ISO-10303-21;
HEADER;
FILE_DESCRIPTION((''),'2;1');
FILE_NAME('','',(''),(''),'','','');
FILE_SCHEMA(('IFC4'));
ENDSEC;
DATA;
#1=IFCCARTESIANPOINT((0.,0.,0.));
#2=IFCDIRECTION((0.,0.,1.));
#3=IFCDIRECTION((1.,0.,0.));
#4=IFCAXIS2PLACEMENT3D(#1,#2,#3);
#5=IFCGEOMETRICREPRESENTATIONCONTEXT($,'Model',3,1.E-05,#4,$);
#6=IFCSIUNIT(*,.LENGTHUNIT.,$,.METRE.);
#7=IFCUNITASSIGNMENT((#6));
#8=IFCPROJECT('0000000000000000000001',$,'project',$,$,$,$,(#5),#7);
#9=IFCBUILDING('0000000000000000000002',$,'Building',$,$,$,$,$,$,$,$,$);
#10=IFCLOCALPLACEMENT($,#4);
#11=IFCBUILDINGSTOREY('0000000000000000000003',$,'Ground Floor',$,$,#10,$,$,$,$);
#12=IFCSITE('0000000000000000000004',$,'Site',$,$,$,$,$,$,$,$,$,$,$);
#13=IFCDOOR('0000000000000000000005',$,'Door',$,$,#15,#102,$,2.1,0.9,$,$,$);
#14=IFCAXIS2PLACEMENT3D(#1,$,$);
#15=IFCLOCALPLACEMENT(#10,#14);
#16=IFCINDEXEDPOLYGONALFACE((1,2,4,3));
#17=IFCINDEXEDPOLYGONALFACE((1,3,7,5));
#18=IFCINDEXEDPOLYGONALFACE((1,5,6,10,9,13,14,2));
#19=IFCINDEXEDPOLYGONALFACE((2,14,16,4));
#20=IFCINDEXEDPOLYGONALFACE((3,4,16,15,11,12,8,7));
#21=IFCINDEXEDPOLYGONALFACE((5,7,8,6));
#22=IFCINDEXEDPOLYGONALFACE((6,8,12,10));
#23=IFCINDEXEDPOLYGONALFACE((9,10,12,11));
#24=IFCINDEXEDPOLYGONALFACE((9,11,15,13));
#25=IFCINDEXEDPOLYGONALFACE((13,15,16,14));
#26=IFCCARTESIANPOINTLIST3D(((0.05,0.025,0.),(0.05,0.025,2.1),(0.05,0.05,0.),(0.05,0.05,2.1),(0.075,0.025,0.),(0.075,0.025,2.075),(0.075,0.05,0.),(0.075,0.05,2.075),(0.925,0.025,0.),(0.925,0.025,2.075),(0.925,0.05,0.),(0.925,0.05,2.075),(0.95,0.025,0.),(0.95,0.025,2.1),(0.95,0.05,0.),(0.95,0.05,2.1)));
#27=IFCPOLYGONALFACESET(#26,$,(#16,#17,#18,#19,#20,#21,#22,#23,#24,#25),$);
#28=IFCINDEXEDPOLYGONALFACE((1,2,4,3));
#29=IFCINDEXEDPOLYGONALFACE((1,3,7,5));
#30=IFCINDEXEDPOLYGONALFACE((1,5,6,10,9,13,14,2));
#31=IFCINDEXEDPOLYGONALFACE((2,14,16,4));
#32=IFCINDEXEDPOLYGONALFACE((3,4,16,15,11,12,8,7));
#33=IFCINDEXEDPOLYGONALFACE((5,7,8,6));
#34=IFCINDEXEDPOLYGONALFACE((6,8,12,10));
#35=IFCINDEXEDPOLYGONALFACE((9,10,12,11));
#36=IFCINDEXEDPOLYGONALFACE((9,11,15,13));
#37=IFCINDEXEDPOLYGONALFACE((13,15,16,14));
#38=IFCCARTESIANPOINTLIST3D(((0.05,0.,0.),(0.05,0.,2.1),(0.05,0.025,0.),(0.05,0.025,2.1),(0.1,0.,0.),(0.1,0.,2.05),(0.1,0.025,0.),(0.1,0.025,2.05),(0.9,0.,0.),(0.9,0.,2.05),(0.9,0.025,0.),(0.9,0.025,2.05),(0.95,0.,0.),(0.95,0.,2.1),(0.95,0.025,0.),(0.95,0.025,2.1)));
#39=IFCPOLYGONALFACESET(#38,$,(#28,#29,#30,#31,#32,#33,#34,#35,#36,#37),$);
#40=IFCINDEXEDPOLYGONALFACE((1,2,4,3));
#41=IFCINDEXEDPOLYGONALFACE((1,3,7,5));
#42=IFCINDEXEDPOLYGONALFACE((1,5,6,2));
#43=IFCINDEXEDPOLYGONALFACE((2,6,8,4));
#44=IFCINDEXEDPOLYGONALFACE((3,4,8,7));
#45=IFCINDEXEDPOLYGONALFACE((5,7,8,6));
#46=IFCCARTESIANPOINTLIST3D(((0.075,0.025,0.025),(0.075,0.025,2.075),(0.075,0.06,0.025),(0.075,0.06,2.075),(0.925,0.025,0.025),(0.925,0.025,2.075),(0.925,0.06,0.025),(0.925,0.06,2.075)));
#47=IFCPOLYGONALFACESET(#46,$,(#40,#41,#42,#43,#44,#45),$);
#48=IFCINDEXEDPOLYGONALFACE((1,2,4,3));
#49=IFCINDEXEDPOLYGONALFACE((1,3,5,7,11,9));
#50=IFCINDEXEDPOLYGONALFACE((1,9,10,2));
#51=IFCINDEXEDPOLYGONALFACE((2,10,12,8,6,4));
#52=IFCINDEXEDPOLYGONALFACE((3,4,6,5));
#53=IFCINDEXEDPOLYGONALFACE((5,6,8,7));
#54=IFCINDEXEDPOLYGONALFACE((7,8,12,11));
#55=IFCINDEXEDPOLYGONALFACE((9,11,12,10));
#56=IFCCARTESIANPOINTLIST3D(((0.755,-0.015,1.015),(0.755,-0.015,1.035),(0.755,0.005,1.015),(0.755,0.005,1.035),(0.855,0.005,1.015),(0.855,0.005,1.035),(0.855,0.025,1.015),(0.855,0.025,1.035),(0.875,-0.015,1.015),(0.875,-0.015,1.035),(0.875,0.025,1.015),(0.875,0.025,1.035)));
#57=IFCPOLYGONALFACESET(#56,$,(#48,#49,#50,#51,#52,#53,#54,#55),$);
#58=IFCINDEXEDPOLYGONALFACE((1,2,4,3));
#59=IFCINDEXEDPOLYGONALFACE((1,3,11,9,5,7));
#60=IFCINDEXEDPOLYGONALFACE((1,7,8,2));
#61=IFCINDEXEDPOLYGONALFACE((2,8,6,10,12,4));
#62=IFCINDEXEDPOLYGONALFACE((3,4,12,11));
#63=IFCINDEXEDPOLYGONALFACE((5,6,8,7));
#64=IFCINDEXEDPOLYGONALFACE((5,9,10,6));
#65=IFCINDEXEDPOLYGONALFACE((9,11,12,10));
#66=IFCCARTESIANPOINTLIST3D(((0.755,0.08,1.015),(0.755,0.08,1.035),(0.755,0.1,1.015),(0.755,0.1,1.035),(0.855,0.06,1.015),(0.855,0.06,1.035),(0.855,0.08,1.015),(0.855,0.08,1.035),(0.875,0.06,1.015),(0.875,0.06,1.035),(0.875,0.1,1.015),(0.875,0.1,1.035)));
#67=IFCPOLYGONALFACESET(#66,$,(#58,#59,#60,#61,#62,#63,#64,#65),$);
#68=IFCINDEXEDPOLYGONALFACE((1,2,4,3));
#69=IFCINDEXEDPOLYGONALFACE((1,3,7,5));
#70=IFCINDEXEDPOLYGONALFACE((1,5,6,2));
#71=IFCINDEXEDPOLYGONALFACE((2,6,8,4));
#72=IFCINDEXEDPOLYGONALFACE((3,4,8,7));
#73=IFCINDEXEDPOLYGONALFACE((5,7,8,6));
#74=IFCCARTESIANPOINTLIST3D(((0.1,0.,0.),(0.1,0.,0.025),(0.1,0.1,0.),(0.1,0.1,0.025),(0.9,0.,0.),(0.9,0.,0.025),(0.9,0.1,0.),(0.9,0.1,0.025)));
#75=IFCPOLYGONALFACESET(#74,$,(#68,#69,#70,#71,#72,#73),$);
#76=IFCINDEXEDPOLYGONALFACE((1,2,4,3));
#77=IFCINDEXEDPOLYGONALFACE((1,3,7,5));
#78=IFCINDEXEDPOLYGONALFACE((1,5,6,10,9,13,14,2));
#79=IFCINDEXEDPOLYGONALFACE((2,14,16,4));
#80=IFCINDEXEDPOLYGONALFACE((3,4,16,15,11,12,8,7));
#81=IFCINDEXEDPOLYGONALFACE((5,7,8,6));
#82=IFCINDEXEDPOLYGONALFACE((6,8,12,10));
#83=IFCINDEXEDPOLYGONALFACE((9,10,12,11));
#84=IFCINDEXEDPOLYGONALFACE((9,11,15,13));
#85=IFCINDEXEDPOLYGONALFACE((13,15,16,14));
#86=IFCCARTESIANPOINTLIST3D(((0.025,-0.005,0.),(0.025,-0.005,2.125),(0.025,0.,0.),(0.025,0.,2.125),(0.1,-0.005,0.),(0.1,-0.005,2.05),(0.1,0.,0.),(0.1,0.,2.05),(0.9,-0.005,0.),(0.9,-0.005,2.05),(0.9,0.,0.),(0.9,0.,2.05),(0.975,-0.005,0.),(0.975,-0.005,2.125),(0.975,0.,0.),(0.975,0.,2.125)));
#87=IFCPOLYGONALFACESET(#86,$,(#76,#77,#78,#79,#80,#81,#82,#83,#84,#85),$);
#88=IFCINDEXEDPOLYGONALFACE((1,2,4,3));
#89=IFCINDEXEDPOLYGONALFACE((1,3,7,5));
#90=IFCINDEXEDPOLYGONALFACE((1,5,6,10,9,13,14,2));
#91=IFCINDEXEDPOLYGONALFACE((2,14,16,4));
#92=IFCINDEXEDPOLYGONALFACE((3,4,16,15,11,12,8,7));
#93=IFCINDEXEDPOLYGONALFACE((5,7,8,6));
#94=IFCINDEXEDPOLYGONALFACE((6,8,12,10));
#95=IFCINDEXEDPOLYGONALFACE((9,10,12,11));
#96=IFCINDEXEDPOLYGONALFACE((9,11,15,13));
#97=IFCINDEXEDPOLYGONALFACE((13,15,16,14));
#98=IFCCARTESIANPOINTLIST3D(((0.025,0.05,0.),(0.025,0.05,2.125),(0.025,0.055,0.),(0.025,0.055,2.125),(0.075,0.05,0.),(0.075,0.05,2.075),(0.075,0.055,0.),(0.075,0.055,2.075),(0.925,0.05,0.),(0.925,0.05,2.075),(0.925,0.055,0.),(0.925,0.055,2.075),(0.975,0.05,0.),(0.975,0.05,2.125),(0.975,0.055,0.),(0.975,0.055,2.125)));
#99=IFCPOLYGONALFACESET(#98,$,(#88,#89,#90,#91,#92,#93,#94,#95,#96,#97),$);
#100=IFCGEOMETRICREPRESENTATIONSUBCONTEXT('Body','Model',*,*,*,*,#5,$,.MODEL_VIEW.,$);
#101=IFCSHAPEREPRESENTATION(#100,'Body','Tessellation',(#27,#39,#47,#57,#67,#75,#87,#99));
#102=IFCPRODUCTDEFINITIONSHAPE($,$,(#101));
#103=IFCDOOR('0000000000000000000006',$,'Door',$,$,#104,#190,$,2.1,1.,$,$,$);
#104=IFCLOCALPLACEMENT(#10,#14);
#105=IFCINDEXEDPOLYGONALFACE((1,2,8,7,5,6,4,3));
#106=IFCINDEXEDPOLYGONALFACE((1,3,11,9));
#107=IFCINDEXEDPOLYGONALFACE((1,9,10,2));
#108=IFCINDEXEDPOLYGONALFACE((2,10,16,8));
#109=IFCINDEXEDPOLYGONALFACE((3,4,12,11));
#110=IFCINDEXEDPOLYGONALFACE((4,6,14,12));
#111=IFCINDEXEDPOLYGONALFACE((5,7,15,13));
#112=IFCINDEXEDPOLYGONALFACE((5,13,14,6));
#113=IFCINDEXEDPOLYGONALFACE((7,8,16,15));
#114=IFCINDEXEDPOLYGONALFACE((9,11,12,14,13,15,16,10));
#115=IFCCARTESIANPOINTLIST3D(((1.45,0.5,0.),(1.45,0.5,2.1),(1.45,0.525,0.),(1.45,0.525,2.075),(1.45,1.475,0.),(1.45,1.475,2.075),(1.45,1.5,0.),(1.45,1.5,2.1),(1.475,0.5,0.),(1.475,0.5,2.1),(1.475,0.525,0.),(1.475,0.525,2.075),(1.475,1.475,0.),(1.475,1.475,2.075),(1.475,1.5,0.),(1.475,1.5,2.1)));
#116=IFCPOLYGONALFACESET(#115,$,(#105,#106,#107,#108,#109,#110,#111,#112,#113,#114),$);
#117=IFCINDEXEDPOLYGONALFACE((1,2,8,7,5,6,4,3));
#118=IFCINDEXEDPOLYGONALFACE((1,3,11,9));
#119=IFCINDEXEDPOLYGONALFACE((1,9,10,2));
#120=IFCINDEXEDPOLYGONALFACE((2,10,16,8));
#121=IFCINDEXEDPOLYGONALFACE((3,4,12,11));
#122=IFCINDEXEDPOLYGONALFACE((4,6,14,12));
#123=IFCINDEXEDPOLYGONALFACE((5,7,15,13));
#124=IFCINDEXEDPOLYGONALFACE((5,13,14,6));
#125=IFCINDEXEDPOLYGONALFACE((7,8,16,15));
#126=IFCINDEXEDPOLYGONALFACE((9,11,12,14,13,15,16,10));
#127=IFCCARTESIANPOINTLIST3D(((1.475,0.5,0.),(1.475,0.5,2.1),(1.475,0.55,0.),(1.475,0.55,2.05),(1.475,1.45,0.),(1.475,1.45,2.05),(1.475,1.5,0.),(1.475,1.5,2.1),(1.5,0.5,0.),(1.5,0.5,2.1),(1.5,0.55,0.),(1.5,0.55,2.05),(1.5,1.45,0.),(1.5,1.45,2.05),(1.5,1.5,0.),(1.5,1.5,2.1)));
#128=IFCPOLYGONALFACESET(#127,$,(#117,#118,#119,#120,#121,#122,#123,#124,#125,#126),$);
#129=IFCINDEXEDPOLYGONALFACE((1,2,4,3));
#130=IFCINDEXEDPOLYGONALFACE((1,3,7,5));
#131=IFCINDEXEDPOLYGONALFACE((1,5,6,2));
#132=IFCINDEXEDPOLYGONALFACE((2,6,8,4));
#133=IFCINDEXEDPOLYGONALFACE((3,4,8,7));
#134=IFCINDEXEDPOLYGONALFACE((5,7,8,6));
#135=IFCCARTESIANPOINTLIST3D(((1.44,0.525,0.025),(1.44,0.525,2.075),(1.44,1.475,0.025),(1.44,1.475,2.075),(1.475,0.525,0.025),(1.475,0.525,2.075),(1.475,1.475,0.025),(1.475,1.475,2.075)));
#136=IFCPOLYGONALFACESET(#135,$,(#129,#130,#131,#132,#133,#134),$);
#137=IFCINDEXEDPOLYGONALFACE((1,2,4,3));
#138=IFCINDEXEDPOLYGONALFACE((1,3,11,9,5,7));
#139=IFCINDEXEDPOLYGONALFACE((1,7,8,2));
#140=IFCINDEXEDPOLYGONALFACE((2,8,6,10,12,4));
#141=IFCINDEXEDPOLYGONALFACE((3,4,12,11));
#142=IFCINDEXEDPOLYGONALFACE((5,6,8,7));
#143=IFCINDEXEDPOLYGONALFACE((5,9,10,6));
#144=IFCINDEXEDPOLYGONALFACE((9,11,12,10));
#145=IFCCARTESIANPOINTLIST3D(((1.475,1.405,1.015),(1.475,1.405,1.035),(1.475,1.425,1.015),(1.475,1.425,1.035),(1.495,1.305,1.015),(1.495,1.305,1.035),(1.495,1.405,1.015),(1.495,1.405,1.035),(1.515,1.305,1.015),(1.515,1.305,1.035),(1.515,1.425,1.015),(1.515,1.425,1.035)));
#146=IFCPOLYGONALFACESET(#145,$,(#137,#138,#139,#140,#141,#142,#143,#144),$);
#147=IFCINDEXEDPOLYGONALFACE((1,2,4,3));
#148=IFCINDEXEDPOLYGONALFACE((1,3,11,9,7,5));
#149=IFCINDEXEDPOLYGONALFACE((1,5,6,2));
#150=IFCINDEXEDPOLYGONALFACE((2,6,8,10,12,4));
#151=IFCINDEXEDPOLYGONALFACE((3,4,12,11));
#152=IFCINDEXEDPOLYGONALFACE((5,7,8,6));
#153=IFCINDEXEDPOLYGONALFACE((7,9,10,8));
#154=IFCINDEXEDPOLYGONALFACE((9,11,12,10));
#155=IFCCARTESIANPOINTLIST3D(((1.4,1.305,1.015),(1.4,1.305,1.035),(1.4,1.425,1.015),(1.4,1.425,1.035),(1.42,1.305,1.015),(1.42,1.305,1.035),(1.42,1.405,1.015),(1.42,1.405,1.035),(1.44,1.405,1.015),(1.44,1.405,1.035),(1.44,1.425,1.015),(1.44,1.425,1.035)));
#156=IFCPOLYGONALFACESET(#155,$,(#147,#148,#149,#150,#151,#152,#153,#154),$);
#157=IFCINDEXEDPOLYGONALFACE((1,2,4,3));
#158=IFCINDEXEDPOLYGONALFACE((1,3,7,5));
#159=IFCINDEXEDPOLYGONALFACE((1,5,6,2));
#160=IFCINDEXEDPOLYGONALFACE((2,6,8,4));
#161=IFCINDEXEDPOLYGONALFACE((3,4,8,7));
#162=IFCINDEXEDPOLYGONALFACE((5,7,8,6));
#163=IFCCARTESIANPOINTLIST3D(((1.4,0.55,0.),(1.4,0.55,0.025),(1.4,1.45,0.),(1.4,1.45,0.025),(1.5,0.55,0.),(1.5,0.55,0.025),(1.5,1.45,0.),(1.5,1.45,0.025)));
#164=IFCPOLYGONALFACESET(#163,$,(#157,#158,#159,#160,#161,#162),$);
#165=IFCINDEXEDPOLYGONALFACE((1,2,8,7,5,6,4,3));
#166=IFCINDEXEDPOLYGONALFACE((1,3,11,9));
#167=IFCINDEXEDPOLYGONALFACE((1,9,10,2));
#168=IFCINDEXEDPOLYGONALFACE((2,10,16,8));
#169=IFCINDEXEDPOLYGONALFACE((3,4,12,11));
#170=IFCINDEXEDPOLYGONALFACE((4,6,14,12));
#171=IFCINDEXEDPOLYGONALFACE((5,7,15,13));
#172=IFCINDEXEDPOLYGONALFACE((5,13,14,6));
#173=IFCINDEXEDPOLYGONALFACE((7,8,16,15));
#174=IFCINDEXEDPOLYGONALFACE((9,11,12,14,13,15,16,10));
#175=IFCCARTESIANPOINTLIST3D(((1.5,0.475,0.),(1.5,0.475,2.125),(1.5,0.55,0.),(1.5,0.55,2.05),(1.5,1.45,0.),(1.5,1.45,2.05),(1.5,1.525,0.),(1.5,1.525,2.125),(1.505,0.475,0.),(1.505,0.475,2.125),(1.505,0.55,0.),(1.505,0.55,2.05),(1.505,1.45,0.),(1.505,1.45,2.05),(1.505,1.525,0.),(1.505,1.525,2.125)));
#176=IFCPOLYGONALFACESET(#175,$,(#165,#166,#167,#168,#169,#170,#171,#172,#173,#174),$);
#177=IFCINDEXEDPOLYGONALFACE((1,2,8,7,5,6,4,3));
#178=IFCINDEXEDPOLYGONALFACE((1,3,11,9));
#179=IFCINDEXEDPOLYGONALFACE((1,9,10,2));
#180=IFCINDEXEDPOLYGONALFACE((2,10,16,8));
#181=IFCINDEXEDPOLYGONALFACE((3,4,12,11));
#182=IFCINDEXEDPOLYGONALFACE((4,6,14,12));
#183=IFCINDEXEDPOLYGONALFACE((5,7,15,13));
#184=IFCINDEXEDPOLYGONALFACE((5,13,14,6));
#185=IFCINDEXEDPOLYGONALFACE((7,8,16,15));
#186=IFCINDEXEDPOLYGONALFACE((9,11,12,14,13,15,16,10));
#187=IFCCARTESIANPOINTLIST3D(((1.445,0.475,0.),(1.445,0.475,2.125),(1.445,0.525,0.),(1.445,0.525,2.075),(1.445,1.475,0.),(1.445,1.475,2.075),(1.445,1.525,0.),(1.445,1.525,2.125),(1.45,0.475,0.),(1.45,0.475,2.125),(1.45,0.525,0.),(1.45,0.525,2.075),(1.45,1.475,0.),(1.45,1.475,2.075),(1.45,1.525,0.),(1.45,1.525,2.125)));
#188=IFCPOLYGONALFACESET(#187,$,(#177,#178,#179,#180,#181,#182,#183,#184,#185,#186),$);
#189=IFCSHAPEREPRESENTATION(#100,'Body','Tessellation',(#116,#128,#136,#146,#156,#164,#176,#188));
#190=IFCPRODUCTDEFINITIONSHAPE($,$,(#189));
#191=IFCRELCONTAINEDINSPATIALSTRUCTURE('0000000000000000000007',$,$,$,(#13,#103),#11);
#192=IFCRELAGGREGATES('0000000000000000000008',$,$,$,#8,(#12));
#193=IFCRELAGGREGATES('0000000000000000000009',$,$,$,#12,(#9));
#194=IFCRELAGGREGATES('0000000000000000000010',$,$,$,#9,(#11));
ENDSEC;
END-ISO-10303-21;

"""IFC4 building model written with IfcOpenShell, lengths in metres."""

from ifc_helpers import new_model, si_unit, frame, origin_with_axes, place, context, subcontext, project, spatial, line, indexed_curve, outline, extrude, element, save


model = new_model("IFC4")

# Units and contexts
model_context = context("Model", 3, precision=1e-05, world=origin_with_axes())
body_context = subcontext(model_context, "Body", "Model", "MODEL_VIEW")
ifc_project = project(units=[si_unit("LENGTHUNIT", "METRE")], contexts=[model_context])

# Site, building, storey
site = spatial("IfcSite", under=ifc_project, Name="Site")
building = spatial("IfcBuilding", under=site, Name="Building")
storey_placement = place(None, origin_with_axes())
storey = spatial("IfcBuildingStorey", under=building, at=storey_placement, Name="Ground Floor")

# Doors
door_1_placement = place(storey_placement, frame((0.05, 0.0, 0.0), z_axis=(0.0, 0.0, 1.0), x_axis=(1.0, 0.0, 0.0)))
element("IfcDoor", 1, at=door_1_placement, inside=storey, Name="Door", OverallHeight=2.1, OverallWidth=0.9, context=body_context, shape_type="SweptSolid", body=[
    extrude(outline(indexed_curve([(0.0, 0.0), (0.0, 2.1), (0.9, 2.1), (0.9, 0.0), (0.875, 0.0), (0.875, 2.075), (0.025, 2.075), (0.025, 0.0)], segments=[line(1, 2, 3, 4, 5, 6, 7, 8, 1)])), frame((0.0, 0.025, 0.0), z_axis=(0.0, -1.0, 0.0), x_axis=(1.0, 0.0, 0.0)), (0.0, 0.0, -1.0), 0.025),
    extrude(outline(indexed_curve([(0.0, 0.0), (0.0, 2.1), (0.9, 2.1), (0.9, 0.0), (0.85, 0.0), (0.85, 2.05), (0.05, 2.05), (0.05, 0.0)], segments=[line(1, 2, 3, 4, 5, 6, 7, 8, 1)])), frame((0.0, 0.0, 0.0), z_axis=(0.0, -1.0, 0.0), x_axis=(1.0, 0.0, 0.0)), (0.0, 0.0, -1.0), 0.025),
    extrude(outline(indexed_curve([(0.0, 0.0), (0.85, 0.0), (0.85, 0.035), (0.0, 0.035)], segments=[line(1, 2, 3, 4, 1)])), frame((0.025, 0.025, 0.025), z_axis=(0.0, 0.0, 1.0), x_axis=(1.0, 0.0, 0.0)), (0.0, 0.0, 1.0), 2.05),
    extrude(outline(indexed_curve([(0.0, 0.0), (0.0, -0.04), (-0.12, -0.04), (-0.12, -0.02), (-0.02, -0.02), (-0.02, 0.0)], segments=[line(1, 2, 3, 4, 5, 6, 1)])), frame((0.825, 0.025, 1.015), z_axis=(0.0, 0.0, 1.0), x_axis=(1.0, 0.0, 0.0)), (0.0, 0.0, 1.0), 0.02),
    extrude(outline(indexed_curve([(0.0, 0.0), (0.0, 0.04), (-0.12, 0.04), (-0.12, 0.02), (-0.02, 0.02), (-0.02, 0.0)], segments=[line(1, 2, 3, 4, 5, 6, 1)])), frame((0.825, 0.06, 1.015), z_axis=(0.0, 0.0, 1.0), x_axis=(1.0, 0.0, 0.0)), (0.0, 0.0, 1.0), 0.02),
    extrude(outline(indexed_curve([(0.0, 0.0), (0.8, 0.0), (0.8, 0.1), (0.0, 0.1)], segments=[line(1, 2, 3, 4, 1)])), frame((0.05, 0.0, 0.0), z_axis=(0.0, 0.0, 1.0), x_axis=(1.0, 0.0, 0.0)), (0.0, 0.0, 1.0), 0.025),
    extrude(outline(indexed_curve([(0.0, 0.0), (0.0, 2.125), (0.95, 2.125), (0.95, 0.0), (0.875, 0.0), (0.875, 2.05), (0.075, 2.05), (0.075, 0.0)], segments=[line(1, 2, 3, 4, 5, 6, 7, 8, 1)])), frame((-0.025, -0.005, 0.0), z_axis=(0.0, -1.0, 0.0), x_axis=(1.0, 0.0, 0.0)), (0.0, 0.0, -1.0), 0.005),
    extrude(outline(indexed_curve([(0.0, 0.0), (0.0, 2.125), (0.95, 2.125), (0.95, 0.0), (0.9, 0.0), (0.9, 2.075), (0.05, 2.075), (0.05, 0.0)], segments=[line(1, 2, 3, 4, 5, 6, 7, 8, 1)])), frame((-0.025, 0.05, 0.0), z_axis=(0.0, -1.0, 0.0), x_axis=(1.0, 0.0, 0.0)), (0.0, 0.0, -1.0), 0.005),
])
door_2_placement = place(storey_placement, frame((1.5, 0.5, 0.0), z_axis=(0.0, 0.0, 1.0), x_axis=(0.0, 1.0, 0.0)))
element("IfcDoor", 2, at=door_2_placement, inside=storey, Name="Door", OverallHeight=2.1, OverallWidth=1.0, context=body_context, shape_type="SweptSolid", body=[
    extrude(outline(indexed_curve([(0.0, 0.0), (0.0, 2.1), (1.0, 2.1), (1.0, 0.0), (0.975, 0.0), (0.975, 2.075), (0.025, 2.075), (0.025, 0.0)], segments=[line(1, 2, 3, 4, 5, 6, 7, 8, 1)])), frame((0.0, 0.025, 0.0), z_axis=(0.0, -1.0, 0.0), x_axis=(1.0, 0.0, 0.0)), (0.0, 0.0, -1.0), 0.025),
    extrude(outline(indexed_curve([(0.0, 0.0), (0.0, 2.1), (1.0, 2.1), (1.0, 0.0), (0.95, 0.0), (0.95, 2.05), (0.05, 2.05), (0.05, 0.0)], segments=[line(1, 2, 3, 4, 5, 6, 7, 8, 1)])), frame((0.0, 0.0, 0.0), z_axis=(0.0, -1.0, 0.0), x_axis=(1.0, 0.0, 0.0)), (0.0, 0.0, -1.0), 0.025),
    extrude(outline(indexed_curve([(0.0, 0.0), (0.95, 0.0), (0.95, 0.035), (0.0, 0.035)], segments=[line(1, 2, 3, 4, 1)])), frame((0.025, 0.025, 0.025), z_axis=(0.0, 0.0, 1.0), x_axis=(1.0, 0.0, 0.0)), (0.0, 0.0, 1.0), 2.05),
    extrude(outline(indexed_curve([(0.0, 0.0), (0.0, -0.04), (-0.12, -0.04), (-0.12, -0.02), (-0.02, -0.02), (-0.02, 0.0)], segments=[line(1, 2, 3, 4, 5, 6, 1)])), frame((0.925, 0.025, 1.015), z_axis=(0.0, 0.0, 1.0), x_axis=(1.0, 0.0, 0.0)), (0.0, 0.0, 1.0), 0.02),
    extrude(outline(indexed_curve([(0.0, 0.0), (0.0, 0.04), (-0.12, 0.04), (-0.12, 0.02), (-0.02, 0.02), (-0.02, 0.0)], segments=[line(1, 2, 3, 4, 5, 6, 1)])), frame((0.925, 0.06, 1.015), z_axis=(0.0, 0.0, 1.0), x_axis=(1.0, 0.0, 0.0)), (0.0, 0.0, 1.0), 0.02),
    extrude(outline(indexed_curve([(0.0, 0.0), (0.9, 0.0), (0.9, 0.1), (0.0, 0.1)], segments=[line(1, 2, 3, 4, 1)])), frame((0.05, 0.0, 0.0), z_axis=(0.0, 0.0, 1.0), x_axis=(1.0, 0.0, 0.0)), (0.0, 0.0, 1.0), 0.025),
    extrude(outline(indexed_curve([(0.0, 0.0), (0.0, 2.125), (1.05, 2.125), (1.05, 0.0), (0.975, 0.0), (0.975, 2.05), (0.075, 2.05), (0.075, 0.0)], segments=[line(1, 2, 3, 4, 5, 6, 7, 8, 1)])), frame((-0.025, -0.005, 0.0), z_axis=(0.0, -1.0, 0.0), x_axis=(1.0, 0.0, 0.0)), (0.0, 0.0, -1.0), 0.005),
    extrude(outline(indexed_curve([(0.0, 0.0), (0.0, 2.125), (1.05, 2.125), (1.05, 0.0), (1.0, 0.0), (1.0, 2.075), (0.05, 2.075), (0.05, 0.0)], segments=[line(1, 2, 3, 4, 5, 6, 7, 8, 1)])), frame((-0.025, 0.05, 0.0), z_axis=(0.0, -1.0, 0.0), x_axis=(1.0, 0.0, 0.0)), (0.0, 0.0, -1.0), 0.005),
])

save(model, "model.ifc")
